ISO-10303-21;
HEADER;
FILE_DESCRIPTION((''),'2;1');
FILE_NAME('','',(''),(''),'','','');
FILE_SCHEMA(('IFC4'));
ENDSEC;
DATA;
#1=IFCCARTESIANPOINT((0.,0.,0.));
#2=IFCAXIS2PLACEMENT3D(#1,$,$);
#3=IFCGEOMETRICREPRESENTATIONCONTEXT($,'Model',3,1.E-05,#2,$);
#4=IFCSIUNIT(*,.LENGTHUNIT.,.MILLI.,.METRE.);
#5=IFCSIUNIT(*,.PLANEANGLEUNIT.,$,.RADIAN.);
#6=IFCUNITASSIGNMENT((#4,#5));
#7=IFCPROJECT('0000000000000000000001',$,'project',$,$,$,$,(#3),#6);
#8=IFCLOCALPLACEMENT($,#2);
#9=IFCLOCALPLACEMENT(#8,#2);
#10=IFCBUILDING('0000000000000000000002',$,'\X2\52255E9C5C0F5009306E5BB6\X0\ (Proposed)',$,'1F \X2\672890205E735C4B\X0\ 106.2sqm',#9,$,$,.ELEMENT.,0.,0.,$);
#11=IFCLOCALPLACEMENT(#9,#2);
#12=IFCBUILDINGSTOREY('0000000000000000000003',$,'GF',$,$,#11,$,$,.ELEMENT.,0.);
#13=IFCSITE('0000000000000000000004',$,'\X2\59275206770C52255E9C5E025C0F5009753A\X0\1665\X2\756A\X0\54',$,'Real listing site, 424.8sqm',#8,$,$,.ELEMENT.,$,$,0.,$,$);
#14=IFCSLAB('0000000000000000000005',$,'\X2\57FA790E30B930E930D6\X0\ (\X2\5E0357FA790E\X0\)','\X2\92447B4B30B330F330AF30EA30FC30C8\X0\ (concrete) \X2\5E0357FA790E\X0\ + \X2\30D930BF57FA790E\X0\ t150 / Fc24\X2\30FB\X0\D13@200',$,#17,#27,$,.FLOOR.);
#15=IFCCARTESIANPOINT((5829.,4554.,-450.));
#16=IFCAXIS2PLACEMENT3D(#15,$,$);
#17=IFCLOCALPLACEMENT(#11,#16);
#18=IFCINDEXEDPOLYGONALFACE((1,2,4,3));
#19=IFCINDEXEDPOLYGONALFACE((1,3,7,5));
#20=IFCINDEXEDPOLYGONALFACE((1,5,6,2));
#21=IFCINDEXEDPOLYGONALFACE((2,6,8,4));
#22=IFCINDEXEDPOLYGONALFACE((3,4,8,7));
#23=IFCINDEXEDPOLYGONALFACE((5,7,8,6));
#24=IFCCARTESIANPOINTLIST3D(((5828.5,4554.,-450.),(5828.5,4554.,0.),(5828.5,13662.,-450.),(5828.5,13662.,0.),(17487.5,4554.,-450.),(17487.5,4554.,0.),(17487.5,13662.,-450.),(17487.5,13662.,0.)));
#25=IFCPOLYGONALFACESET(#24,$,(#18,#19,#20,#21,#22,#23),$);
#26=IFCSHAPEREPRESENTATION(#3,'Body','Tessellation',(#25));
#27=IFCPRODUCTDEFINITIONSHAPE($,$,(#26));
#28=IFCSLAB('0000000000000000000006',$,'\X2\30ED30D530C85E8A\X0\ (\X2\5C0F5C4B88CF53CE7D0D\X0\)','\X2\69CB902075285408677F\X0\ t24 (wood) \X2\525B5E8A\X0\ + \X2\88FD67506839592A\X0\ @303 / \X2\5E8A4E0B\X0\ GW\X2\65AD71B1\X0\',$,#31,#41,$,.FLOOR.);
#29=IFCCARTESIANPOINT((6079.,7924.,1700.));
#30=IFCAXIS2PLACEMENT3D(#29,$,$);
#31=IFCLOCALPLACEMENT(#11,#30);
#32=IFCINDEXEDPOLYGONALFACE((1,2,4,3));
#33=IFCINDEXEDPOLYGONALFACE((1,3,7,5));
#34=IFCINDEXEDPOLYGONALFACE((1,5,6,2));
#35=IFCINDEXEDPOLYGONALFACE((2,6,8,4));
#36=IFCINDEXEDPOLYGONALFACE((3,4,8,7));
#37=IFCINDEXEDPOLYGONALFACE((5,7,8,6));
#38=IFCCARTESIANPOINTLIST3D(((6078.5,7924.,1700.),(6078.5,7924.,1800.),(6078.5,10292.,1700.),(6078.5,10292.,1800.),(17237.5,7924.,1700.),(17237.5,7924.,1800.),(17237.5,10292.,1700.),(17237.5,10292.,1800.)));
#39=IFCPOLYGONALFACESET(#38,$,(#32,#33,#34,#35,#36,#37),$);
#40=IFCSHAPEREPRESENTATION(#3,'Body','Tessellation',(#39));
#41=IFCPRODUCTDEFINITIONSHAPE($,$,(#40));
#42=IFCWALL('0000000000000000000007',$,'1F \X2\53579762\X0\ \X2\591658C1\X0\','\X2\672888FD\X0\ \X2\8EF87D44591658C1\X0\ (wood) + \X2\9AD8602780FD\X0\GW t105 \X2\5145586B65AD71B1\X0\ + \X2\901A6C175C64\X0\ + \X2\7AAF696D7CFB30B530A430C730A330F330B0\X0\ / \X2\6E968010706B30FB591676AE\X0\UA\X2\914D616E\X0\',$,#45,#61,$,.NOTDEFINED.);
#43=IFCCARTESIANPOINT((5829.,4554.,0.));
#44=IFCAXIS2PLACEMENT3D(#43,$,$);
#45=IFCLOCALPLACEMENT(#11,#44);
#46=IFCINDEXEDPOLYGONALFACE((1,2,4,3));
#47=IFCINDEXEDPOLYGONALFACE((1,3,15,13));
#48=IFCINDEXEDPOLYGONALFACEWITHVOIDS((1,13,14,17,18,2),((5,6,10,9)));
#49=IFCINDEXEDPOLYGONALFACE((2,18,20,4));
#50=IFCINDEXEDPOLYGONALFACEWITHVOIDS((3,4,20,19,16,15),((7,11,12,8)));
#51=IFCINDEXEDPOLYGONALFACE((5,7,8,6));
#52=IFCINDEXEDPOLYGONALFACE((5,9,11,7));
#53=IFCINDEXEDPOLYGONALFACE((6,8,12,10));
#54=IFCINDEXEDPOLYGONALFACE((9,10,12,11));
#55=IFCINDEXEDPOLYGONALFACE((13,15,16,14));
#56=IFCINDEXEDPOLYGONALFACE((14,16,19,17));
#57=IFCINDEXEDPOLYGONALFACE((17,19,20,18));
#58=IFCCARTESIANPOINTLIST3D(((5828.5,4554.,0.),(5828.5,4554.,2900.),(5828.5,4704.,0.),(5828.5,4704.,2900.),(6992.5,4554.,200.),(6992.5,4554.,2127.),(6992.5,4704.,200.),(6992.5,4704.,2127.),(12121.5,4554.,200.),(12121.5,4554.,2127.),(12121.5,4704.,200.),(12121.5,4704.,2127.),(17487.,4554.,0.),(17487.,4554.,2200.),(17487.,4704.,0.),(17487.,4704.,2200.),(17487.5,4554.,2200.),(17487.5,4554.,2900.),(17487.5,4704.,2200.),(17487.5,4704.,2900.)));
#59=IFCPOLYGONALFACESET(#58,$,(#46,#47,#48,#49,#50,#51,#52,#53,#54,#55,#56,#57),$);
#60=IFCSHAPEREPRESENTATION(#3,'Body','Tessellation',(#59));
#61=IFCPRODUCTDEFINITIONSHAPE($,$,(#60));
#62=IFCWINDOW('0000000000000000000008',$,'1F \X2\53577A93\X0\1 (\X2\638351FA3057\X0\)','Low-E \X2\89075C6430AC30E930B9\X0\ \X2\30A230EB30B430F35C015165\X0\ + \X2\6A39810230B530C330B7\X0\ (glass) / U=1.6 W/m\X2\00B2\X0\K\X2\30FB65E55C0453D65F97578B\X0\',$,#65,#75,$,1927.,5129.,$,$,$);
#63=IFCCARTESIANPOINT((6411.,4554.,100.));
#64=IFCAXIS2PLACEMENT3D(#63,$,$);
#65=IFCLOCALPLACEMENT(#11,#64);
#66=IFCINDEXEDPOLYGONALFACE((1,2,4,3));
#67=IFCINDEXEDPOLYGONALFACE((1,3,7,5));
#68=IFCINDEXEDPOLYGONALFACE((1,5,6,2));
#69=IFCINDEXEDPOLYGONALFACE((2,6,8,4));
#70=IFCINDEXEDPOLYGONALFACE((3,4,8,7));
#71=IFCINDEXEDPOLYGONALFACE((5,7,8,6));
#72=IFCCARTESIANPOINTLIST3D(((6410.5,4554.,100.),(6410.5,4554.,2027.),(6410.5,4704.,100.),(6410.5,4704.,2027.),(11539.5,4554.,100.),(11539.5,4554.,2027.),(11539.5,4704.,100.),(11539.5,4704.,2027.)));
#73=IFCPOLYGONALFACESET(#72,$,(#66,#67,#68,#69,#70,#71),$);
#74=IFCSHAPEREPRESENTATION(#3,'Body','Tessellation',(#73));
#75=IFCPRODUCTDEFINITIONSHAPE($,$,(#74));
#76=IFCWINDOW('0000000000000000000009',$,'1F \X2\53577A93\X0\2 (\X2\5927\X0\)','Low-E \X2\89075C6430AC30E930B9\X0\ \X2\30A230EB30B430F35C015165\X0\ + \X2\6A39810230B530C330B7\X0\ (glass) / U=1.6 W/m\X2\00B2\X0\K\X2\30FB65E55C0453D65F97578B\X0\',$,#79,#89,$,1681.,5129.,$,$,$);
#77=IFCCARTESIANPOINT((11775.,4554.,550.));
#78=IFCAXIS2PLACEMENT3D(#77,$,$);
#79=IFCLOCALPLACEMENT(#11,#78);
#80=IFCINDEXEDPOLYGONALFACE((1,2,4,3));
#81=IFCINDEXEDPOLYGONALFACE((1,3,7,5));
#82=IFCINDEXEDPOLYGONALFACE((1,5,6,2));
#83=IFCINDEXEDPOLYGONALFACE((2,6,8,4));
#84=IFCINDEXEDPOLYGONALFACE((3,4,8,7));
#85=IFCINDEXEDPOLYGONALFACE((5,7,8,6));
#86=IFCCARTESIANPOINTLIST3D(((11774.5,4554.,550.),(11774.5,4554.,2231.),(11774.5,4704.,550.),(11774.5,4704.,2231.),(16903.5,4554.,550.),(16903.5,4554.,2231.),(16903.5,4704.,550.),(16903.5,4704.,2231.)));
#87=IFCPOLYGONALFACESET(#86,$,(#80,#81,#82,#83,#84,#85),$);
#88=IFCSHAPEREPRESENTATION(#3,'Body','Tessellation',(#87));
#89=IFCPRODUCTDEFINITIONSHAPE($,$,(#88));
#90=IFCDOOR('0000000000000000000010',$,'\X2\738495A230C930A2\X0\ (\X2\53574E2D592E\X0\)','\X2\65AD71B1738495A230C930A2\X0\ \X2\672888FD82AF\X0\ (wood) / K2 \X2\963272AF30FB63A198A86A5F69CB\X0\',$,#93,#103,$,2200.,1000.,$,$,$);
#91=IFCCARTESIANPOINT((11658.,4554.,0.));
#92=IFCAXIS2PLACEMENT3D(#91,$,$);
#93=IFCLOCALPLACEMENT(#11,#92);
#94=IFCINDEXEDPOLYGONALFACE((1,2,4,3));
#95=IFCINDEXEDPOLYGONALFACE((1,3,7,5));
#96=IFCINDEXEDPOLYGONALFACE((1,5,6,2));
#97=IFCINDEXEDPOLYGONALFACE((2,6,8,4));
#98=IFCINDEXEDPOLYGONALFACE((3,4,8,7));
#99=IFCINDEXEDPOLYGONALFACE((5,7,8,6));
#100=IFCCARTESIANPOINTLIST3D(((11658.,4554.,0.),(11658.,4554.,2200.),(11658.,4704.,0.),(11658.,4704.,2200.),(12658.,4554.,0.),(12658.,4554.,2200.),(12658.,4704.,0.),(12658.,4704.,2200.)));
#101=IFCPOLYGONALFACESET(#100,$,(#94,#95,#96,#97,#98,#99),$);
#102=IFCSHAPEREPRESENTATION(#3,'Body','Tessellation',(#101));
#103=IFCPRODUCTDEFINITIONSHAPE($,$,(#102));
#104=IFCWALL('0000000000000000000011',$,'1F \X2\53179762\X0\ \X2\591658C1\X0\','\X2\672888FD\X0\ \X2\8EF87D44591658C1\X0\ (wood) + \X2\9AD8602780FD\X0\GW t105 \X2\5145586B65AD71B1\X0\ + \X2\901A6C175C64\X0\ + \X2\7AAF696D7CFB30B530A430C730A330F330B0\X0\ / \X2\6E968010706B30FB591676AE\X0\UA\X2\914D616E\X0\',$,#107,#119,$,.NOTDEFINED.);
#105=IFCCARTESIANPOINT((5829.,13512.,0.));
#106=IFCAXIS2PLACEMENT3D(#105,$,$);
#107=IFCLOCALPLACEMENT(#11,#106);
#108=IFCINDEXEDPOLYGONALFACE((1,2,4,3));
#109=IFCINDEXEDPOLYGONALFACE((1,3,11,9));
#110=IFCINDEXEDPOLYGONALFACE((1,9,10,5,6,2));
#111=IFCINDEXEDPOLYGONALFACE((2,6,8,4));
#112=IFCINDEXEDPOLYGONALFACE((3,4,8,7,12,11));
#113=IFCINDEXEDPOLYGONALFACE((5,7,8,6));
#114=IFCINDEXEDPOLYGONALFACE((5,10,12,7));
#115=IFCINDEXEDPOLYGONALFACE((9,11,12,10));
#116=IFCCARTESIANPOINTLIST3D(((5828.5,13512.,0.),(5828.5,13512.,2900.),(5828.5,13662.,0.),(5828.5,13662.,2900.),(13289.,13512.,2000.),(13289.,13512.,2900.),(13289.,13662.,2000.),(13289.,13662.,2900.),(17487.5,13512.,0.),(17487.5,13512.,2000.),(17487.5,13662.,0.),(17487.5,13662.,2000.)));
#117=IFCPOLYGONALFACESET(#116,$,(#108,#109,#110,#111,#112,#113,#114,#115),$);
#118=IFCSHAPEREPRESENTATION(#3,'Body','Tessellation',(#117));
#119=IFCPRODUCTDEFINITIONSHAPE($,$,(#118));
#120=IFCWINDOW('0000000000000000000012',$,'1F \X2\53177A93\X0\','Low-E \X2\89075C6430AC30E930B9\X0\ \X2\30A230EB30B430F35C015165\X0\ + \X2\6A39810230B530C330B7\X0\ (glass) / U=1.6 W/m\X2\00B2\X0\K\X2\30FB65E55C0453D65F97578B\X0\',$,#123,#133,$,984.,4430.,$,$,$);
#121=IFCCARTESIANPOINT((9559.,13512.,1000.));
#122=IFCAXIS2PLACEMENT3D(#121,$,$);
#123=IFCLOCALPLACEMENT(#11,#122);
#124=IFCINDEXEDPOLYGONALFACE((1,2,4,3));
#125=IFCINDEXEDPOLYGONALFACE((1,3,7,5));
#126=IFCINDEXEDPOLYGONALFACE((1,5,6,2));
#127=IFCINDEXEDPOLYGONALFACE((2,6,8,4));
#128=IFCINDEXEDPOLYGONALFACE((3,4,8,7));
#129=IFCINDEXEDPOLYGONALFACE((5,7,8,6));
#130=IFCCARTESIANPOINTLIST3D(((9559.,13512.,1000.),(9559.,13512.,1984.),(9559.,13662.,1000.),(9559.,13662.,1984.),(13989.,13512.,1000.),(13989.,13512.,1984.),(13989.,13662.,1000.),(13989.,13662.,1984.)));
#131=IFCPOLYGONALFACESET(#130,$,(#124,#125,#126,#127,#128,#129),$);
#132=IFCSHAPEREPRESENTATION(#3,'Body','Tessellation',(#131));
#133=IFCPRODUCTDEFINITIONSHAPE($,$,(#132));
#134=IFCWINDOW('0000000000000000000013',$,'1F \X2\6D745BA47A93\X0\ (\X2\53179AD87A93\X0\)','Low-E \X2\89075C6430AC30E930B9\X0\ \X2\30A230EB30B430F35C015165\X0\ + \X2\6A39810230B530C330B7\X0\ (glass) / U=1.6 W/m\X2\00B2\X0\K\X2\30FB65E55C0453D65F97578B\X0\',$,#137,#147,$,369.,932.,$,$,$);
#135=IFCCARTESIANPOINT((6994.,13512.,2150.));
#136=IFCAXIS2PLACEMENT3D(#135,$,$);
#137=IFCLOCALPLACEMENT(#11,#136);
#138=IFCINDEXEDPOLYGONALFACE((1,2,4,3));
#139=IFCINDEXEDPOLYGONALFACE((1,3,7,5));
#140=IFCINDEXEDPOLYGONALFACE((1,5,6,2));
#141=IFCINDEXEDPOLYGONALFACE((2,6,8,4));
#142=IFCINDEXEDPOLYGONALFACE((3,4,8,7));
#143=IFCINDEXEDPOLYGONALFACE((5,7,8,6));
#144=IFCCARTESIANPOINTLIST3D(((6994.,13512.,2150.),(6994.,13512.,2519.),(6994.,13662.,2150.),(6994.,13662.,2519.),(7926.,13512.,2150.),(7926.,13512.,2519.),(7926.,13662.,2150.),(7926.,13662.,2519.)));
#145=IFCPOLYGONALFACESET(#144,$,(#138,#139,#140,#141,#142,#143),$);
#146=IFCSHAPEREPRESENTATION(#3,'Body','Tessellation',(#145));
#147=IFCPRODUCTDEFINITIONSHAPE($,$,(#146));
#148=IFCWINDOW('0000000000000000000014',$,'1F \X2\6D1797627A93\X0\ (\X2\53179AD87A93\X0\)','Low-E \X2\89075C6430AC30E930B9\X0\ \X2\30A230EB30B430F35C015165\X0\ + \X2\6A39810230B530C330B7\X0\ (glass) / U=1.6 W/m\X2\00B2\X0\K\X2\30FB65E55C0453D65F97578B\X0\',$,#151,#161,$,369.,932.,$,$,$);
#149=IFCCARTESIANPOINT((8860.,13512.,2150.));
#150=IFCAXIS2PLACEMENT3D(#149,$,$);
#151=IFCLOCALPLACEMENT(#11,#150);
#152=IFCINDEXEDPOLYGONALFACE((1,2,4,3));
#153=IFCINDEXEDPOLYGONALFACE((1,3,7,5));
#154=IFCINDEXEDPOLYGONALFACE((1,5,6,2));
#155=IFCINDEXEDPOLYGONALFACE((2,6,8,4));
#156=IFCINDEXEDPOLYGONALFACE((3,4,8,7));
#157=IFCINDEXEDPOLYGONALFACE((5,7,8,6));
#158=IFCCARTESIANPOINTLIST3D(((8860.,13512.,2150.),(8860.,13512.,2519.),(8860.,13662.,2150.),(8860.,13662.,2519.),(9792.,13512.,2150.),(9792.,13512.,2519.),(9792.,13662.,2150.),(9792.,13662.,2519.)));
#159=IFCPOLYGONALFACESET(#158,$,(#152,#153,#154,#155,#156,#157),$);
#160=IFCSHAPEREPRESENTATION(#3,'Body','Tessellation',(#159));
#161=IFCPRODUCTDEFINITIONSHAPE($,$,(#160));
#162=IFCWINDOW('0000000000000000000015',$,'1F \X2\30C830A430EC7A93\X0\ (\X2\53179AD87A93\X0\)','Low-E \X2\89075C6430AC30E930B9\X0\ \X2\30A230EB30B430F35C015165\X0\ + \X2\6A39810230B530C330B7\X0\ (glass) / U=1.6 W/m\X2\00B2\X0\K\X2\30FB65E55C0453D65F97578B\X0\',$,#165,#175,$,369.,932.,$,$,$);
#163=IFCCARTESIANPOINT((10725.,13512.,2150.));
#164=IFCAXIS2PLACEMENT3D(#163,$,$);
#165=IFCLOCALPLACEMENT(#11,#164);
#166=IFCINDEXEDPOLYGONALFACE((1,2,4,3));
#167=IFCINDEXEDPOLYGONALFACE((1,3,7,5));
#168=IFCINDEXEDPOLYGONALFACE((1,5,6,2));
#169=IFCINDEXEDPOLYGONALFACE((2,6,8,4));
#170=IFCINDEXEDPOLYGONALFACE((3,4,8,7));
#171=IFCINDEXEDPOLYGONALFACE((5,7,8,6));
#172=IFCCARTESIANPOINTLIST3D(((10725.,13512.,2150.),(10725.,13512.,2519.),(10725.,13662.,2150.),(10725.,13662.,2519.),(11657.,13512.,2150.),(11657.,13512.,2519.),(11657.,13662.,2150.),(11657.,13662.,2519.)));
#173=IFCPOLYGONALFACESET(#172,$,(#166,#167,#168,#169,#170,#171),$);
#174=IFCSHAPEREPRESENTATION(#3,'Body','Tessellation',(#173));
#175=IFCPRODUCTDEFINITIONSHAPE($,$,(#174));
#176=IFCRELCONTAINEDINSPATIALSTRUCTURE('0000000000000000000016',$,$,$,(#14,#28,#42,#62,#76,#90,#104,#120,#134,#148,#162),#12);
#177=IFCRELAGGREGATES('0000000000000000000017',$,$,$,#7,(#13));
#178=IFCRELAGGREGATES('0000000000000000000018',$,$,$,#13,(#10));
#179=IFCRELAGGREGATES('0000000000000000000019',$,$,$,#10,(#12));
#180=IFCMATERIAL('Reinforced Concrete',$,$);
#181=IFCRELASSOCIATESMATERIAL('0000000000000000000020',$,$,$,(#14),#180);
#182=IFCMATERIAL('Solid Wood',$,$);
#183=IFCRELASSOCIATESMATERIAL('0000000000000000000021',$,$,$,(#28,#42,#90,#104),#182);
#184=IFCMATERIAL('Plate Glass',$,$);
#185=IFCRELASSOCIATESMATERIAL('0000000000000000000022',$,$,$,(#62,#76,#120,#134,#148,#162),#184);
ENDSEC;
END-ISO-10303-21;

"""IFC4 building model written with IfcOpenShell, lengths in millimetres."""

from ifc_helpers import new_model, si_unit, frame, frame_2d, origin, place, context, project, spatial, rectangle, extrude, material, element, fill, save


model = new_model("IFC4")

# Units and contexts
model_context = context("Model", 3, precision=1e-05, world=origin())
ifc_project = project(units=[si_unit("LENGTHUNIT", "METRE", prefix="MILLI"), si_unit("PLANEANGLEUNIT", "RADIAN")], contexts=[model_context])

# Site, building, storey
site_placement = place(None, origin())
site = spatial("IfcSite", under=ifc_project, at=site_placement, Name="大分県別府市小倉町1665番54", ObjectType="Real listing site, 424.8sqm", CompositionType="ELEMENT", RefElevation=0.0)
building_placement = place(site_placement, origin())
building = spatial("IfcBuilding", under=site, at=building_placement, Name="別府小倉の家 (Proposed)", ObjectType="1F 木造平屋 106.2sqm", CompositionType="ELEMENT", ElevationOfRefHeight=0.0, ElevationOfTerrain=0.0)
storey_placement = place(building_placement, origin())
storey = spatial("IfcBuildingStorey", under=building, at=storey_placement, Name="GF", CompositionType="ELEMENT", Elevation=0.0)

# Slabs
ifc_material_1 = material(Name="Reinforced Concrete")
slab_1_placement = place(storey_placement, frame((5829.0, 4554.0, -450.0)))
element("IfcSlab", 1, at=slab_1_placement, inside=storey, material=ifc_material_1, Name="基礎スラブ (布基礎)", Description="鉄筋コンクリート (concrete) 布基礎 + ベタ基礎 t150 / Fc24・D13@200", PredefinedType="FLOOR", context=model_context, shape_type="SweptSolid", body=[
    extrude(rectangle(XDim=11659.0, YDim=9108.0, at=frame_2d((5829.0, 4554.0))), frame((5829.0, 4554.0, -450.0)), (0.0, 0.0, 1.0), 450.0),
])
ifc_material_2 = material(Name="Solid Wood")
slab_2_placement = place(storey_placement, frame((6079.0, 7924.0, 1700.0)))
element("IfcSlab", 2, at=slab_2_placement, inside=storey, material=ifc_material_2, Name="ロフト床 (小屋裏収納)", Description="構造用合板 t24 (wood) 剛床 + 製材根太 @303 / 床下 GW断熱", PredefinedType="FLOOR", context=model_context, shape_type="SweptSolid", body=[
    extrude(rectangle(XDim=11159.0, YDim=2368.0, at=frame_2d((5579.0, 1184.0))), frame((6079.0, 7924.0, 1700.0)), (0.0, 0.0, 1.0), 100.0),
])

# Wall, openings, windows, door
wall_1_placement = place(storey_placement, frame((5829.0, 4554.0, 0.0)))
wall_1 = element("IfcWall", 3, at=wall_1_placement, inside=storey, material=ifc_material_2, Name="1F 南面 外壁", Description="木製 軸組外壁 (wood) + 高性能GW t105 充填断熱 + 通気層 + 窯業系サイディング / 準耐火・外皮UA配慮", PredefinedType="NOTDEFINED", context=model_context, shape_type="SweptSolid", body=[
    extrude(rectangle(XDim=11659.0, YDim=150.0, at=frame_2d((5829.0, 75.0))), frame((5829.0, 4554.0, 0.0)), (0.0, 0.0, 1.0), 2900.0),
])
opening_1_placement = place(storey_placement, frame((6411.0, 4554.0, 100.0)))
opening_1 = element("IfcOpeningElement", 4, at=opening_1_placement, cuts=wall_1, PredefinedType="NOTDEFINED", context=model_context, shape_type="SweptSolid", body=[
    extrude(rectangle(XDim=5129.0, YDim=150.0, at=frame_2d((2564.0, 75.0))), frame((6411.0, 4554.0, 100.0)), (0.0, 0.0, 1.0), 1927.0),
])
opening_2_placement = place(storey_placement, frame((11775.0, 4554.0, 550.0)))
opening_2 = element("IfcOpeningElement", 5, at=opening_2_placement, cuts=wall_1, PredefinedType="NOTDEFINED", context=model_context, shape_type="SweptSolid", body=[
    extrude(rectangle(XDim=5129.0, YDim=150.0, at=frame_2d((2564.0, 75.0))), frame((11775.0, 4554.0, 550.0)), (0.0, 0.0, 1.0), 1681.0),
])
opening_3_placement = place(storey_placement, frame((11658.0, 4554.0, 0.0)))
opening_3 = element("IfcOpeningElement", 6, at=opening_3_placement, cuts=wall_1, PredefinedType="NOTDEFINED", context=model_context, shape_type="SweptSolid", body=[
    extrude(rectangle(XDim=1000.0, YDim=150.0, at=frame_2d((500.0, 75.0))), frame((11658.0, 4554.0, 0.0)), (0.0, 0.0, 1.0), 2200.0),
])
ifc_material_3 = material(Name="Plate Glass")
window_1_placement = place(storey_placement, frame((6411.0, 4554.0, 100.0)))
window_1 = element("IfcWindow", 7, at=window_1_placement, inside=storey, material=ifc_material_3, Name="1F 南窓1 (掃出し)", Description="Low-E 複層ガラス アルゴン封入 + 樹脂サッシ (glass) / U=1.6 W/m²K・日射取得型", OverallHeight=1927.0, OverallWidth=5129.0, context=model_context, shape_type="SweptSolid", body=[
    extrude(rectangle(XDim=5129.0, YDim=150.0, at=frame_2d((2564.0, 75.0))), frame((6411.0, 4554.0, 100.0)), (0.0, 0.0, 1.0), 1927.0),
])
fill(opening_1, window_1)
window_2_placement = place(storey_placement, frame((11775.0, 4554.0, 550.0)))
window_2 = element("IfcWindow", 8, at=window_2_placement, inside=storey, material=ifc_material_3, Name="1F 南窓2 (大)", Description="Low-E 複層ガラス アルゴン封入 + 樹脂サッシ (glass) / U=1.6 W/m²K・日射取得型", OverallHeight=1681.0, OverallWidth=5129.0, context=model_context, shape_type="SweptSolid", body=[
    extrude(rectangle(XDim=5129.0, YDim=150.0, at=frame_2d((2564.0, 75.0))), frame((11775.0, 4554.0, 550.0)), (0.0, 0.0, 1.0), 1681.0),
])
fill(opening_2, window_2)
door_1_placement = place(storey_placement, frame((11658.0, 4554.0, 0.0)))
door_1 = element("IfcDoor", 9, at=door_1_placement, inside=storey, material=ifc_material_2, Name="玄関ドア (南中央)", Description="断熱玄関ドア 木製芯 (wood) / K2 防犯・採風機構", OverallHeight=2200.0, OverallWidth=1000.0, context=model_context, shape_type="SweptSolid", body=[
    extrude(rectangle(XDim=1000.0, YDim=150.0, at=frame_2d((500.0, 75.0))), frame((11658.0, 4554.0, 0.0)), (0.0, 0.0, 1.0), 2200.0),
])
fill(opening_3, door_1)

# Wall, openings, windows
wall_2_placement = place(storey_placement, frame((5829.0, 13512.0, 0.0)))
wall_2 = element("IfcWall", 10, at=wall_2_placement, inside=storey, material=ifc_material_2, Name="1F 北面 外壁", Description="木製 軸組外壁 (wood) + 高性能GW t105 充填断熱 + 通気層 + 窯業系サイディング / 準耐火・外皮UA配慮", PredefinedType="NOTDEFINED", context=model_context, shape_type="SweptSolid", body=[
    extrude(rectangle(XDim=11659.0, YDim=150.0, at=frame_2d((5829.0, 75.0))), frame((5829.0, 13512.0, 0.0)), (0.0, 0.0, 1.0), 2900.0),
])
opening_4_placement = place(storey_placement, frame((9559.0, 13512.0, 1000.0)))
opening_4 = element("IfcOpeningElement", 11, at=opening_4_placement, cuts=wall_2, PredefinedType="NOTDEFINED", context=model_context, shape_type="SweptSolid", body=[
    extrude(rectangle(XDim=4430.0, YDim=150.0, at=frame_2d((2215.0, 75.0))), frame((9559.0, 13512.0, 1000.0)), (0.0, 0.0, 1.0), 984.0),
])
opening_5_placement = place(storey_placement, frame((6994.0, 13512.0, 2150.0)))
opening_5 = element("IfcOpeningElement", 12, at=opening_5_placement, cuts=wall_2, PredefinedType="NOTDEFINED", context=model_context, shape_type="SweptSolid", body=[
    extrude(rectangle(XDim=932.0, YDim=150.0, at=frame_2d((466.0, 75.0))), frame((6994.0, 13512.0, 2150.0)), (0.0, 0.0, 1.0), 369.0),
])
opening_6_placement = place(storey_placement, frame((8860.0, 13512.0, 2150.0)))
opening_6 = element("IfcOpeningElement", 13, at=opening_6_placement, cuts=wall_2, PredefinedType="NOTDEFINED", context=model_context, shape_type="SweptSolid", body=[
    extrude(rectangle(XDim=932.0, YDim=150.0, at=frame_2d((466.0, 75.0))), frame((8860.0, 13512.0, 2150.0)), (0.0, 0.0, 1.0), 369.0),
])
opening_7_placement = place(storey_placement, frame((10725.0, 13512.0, 2150.0)))
opening_7 = element("IfcOpeningElement", 14, at=opening_7_placement, cuts=wall_2, PredefinedType="NOTDEFINED", context=model_context, shape_type="SweptSolid", body=[
    extrude(rectangle(XDim=932.0, YDim=150.0, at=frame_2d((466.0, 75.0))), frame((10725.0, 13512.0, 2150.0)), (0.0, 0.0, 1.0), 369.0),
])
window_3_placement = place(storey_placement, frame((9559.0, 13512.0, 1000.0)))
window_3 = element("IfcWindow", 15, at=window_3_placement, inside=storey, material=ifc_material_3, Name="1F 北窓", Description="Low-E 複層ガラス アルゴン封入 + 樹脂サッシ (glass) / U=1.6 W/m²K・日射取得型", OverallHeight=984.0, OverallWidth=4430.0, context=model_context, shape_type="SweptSolid", body=[
    extrude(rectangle(XDim=4430.0, YDim=150.0, at=frame_2d((2215.0, 75.0))), frame((9559.0, 13512.0, 1000.0)), (0.0, 0.0, 1.0), 984.0),
])
fill(opening_4, window_3)
window_4_placement = place(storey_placement, frame((6994.0, 13512.0, 2150.0)))
window_4 = element("IfcWindow", 16, at=window_4_placement, inside=storey, material=ifc_material_3, Name="1F 浴室窓 (北高窓)", Description="Low-E 複層ガラス アルゴン封入 + 樹脂サッシ (glass) / U=1.6 W/m²K・日射取得型", OverallHeight=369.0, OverallWidth=932.0, context=model_context, shape_type="SweptSolid", body=[
    extrude(rectangle(XDim=932.0, YDim=150.0, at=frame_2d((466.0, 75.0))), frame((6994.0, 13512.0, 2150.0)), (0.0, 0.0, 1.0), 369.0),
])
fill(opening_5, window_4)
window_5_placement = place(storey_placement, frame((8860.0, 13512.0, 2150.0)))
window_5 = element("IfcWindow", 17, at=window_5_placement, inside=storey, material=ifc_material_3, Name="1F 洗面窓 (北高窓)", Description="Low-E 複層ガラス アルゴン封入 + 樹脂サッシ (glass) / U=1.6 W/m²K・日射取得型", OverallHeight=369.0, OverallWidth=932.0, context=model_context, shape_type="SweptSolid", body=[
    extrude(rectangle(XDim=932.0, YDim=150.0, at=frame_2d((466.0, 75.0))), frame((8860.0, 13512.0, 2150.0)), (0.0, 0.0, 1.0), 369.0),
])
fill(opening_6, window_5)
window_6_placement = place(storey_placement, frame((10725.0, 13512.0, 2150.0)))
window_6 = element("IfcWindow", 18, at=window_6_placement, inside=storey, material=ifc_material_3, Name="1F トイレ窓 (北高窓)", Description="Low-E 複層ガラス アルゴン封入 + 樹脂サッシ (glass) / U=1.6 W/m²K・日射取得型", OverallHeight=369.0, OverallWidth=932.0, context=model_context, shape_type="SweptSolid", body=[
    extrude(rectangle(XDim=932.0, YDim=150.0, at=frame_2d((466.0, 75.0))), frame((10725.0, 13512.0, 2150.0)), (0.0, 0.0, 1.0), 369.0),
])
fill(opening_7, window_6)

save(model, "model.ifc")
